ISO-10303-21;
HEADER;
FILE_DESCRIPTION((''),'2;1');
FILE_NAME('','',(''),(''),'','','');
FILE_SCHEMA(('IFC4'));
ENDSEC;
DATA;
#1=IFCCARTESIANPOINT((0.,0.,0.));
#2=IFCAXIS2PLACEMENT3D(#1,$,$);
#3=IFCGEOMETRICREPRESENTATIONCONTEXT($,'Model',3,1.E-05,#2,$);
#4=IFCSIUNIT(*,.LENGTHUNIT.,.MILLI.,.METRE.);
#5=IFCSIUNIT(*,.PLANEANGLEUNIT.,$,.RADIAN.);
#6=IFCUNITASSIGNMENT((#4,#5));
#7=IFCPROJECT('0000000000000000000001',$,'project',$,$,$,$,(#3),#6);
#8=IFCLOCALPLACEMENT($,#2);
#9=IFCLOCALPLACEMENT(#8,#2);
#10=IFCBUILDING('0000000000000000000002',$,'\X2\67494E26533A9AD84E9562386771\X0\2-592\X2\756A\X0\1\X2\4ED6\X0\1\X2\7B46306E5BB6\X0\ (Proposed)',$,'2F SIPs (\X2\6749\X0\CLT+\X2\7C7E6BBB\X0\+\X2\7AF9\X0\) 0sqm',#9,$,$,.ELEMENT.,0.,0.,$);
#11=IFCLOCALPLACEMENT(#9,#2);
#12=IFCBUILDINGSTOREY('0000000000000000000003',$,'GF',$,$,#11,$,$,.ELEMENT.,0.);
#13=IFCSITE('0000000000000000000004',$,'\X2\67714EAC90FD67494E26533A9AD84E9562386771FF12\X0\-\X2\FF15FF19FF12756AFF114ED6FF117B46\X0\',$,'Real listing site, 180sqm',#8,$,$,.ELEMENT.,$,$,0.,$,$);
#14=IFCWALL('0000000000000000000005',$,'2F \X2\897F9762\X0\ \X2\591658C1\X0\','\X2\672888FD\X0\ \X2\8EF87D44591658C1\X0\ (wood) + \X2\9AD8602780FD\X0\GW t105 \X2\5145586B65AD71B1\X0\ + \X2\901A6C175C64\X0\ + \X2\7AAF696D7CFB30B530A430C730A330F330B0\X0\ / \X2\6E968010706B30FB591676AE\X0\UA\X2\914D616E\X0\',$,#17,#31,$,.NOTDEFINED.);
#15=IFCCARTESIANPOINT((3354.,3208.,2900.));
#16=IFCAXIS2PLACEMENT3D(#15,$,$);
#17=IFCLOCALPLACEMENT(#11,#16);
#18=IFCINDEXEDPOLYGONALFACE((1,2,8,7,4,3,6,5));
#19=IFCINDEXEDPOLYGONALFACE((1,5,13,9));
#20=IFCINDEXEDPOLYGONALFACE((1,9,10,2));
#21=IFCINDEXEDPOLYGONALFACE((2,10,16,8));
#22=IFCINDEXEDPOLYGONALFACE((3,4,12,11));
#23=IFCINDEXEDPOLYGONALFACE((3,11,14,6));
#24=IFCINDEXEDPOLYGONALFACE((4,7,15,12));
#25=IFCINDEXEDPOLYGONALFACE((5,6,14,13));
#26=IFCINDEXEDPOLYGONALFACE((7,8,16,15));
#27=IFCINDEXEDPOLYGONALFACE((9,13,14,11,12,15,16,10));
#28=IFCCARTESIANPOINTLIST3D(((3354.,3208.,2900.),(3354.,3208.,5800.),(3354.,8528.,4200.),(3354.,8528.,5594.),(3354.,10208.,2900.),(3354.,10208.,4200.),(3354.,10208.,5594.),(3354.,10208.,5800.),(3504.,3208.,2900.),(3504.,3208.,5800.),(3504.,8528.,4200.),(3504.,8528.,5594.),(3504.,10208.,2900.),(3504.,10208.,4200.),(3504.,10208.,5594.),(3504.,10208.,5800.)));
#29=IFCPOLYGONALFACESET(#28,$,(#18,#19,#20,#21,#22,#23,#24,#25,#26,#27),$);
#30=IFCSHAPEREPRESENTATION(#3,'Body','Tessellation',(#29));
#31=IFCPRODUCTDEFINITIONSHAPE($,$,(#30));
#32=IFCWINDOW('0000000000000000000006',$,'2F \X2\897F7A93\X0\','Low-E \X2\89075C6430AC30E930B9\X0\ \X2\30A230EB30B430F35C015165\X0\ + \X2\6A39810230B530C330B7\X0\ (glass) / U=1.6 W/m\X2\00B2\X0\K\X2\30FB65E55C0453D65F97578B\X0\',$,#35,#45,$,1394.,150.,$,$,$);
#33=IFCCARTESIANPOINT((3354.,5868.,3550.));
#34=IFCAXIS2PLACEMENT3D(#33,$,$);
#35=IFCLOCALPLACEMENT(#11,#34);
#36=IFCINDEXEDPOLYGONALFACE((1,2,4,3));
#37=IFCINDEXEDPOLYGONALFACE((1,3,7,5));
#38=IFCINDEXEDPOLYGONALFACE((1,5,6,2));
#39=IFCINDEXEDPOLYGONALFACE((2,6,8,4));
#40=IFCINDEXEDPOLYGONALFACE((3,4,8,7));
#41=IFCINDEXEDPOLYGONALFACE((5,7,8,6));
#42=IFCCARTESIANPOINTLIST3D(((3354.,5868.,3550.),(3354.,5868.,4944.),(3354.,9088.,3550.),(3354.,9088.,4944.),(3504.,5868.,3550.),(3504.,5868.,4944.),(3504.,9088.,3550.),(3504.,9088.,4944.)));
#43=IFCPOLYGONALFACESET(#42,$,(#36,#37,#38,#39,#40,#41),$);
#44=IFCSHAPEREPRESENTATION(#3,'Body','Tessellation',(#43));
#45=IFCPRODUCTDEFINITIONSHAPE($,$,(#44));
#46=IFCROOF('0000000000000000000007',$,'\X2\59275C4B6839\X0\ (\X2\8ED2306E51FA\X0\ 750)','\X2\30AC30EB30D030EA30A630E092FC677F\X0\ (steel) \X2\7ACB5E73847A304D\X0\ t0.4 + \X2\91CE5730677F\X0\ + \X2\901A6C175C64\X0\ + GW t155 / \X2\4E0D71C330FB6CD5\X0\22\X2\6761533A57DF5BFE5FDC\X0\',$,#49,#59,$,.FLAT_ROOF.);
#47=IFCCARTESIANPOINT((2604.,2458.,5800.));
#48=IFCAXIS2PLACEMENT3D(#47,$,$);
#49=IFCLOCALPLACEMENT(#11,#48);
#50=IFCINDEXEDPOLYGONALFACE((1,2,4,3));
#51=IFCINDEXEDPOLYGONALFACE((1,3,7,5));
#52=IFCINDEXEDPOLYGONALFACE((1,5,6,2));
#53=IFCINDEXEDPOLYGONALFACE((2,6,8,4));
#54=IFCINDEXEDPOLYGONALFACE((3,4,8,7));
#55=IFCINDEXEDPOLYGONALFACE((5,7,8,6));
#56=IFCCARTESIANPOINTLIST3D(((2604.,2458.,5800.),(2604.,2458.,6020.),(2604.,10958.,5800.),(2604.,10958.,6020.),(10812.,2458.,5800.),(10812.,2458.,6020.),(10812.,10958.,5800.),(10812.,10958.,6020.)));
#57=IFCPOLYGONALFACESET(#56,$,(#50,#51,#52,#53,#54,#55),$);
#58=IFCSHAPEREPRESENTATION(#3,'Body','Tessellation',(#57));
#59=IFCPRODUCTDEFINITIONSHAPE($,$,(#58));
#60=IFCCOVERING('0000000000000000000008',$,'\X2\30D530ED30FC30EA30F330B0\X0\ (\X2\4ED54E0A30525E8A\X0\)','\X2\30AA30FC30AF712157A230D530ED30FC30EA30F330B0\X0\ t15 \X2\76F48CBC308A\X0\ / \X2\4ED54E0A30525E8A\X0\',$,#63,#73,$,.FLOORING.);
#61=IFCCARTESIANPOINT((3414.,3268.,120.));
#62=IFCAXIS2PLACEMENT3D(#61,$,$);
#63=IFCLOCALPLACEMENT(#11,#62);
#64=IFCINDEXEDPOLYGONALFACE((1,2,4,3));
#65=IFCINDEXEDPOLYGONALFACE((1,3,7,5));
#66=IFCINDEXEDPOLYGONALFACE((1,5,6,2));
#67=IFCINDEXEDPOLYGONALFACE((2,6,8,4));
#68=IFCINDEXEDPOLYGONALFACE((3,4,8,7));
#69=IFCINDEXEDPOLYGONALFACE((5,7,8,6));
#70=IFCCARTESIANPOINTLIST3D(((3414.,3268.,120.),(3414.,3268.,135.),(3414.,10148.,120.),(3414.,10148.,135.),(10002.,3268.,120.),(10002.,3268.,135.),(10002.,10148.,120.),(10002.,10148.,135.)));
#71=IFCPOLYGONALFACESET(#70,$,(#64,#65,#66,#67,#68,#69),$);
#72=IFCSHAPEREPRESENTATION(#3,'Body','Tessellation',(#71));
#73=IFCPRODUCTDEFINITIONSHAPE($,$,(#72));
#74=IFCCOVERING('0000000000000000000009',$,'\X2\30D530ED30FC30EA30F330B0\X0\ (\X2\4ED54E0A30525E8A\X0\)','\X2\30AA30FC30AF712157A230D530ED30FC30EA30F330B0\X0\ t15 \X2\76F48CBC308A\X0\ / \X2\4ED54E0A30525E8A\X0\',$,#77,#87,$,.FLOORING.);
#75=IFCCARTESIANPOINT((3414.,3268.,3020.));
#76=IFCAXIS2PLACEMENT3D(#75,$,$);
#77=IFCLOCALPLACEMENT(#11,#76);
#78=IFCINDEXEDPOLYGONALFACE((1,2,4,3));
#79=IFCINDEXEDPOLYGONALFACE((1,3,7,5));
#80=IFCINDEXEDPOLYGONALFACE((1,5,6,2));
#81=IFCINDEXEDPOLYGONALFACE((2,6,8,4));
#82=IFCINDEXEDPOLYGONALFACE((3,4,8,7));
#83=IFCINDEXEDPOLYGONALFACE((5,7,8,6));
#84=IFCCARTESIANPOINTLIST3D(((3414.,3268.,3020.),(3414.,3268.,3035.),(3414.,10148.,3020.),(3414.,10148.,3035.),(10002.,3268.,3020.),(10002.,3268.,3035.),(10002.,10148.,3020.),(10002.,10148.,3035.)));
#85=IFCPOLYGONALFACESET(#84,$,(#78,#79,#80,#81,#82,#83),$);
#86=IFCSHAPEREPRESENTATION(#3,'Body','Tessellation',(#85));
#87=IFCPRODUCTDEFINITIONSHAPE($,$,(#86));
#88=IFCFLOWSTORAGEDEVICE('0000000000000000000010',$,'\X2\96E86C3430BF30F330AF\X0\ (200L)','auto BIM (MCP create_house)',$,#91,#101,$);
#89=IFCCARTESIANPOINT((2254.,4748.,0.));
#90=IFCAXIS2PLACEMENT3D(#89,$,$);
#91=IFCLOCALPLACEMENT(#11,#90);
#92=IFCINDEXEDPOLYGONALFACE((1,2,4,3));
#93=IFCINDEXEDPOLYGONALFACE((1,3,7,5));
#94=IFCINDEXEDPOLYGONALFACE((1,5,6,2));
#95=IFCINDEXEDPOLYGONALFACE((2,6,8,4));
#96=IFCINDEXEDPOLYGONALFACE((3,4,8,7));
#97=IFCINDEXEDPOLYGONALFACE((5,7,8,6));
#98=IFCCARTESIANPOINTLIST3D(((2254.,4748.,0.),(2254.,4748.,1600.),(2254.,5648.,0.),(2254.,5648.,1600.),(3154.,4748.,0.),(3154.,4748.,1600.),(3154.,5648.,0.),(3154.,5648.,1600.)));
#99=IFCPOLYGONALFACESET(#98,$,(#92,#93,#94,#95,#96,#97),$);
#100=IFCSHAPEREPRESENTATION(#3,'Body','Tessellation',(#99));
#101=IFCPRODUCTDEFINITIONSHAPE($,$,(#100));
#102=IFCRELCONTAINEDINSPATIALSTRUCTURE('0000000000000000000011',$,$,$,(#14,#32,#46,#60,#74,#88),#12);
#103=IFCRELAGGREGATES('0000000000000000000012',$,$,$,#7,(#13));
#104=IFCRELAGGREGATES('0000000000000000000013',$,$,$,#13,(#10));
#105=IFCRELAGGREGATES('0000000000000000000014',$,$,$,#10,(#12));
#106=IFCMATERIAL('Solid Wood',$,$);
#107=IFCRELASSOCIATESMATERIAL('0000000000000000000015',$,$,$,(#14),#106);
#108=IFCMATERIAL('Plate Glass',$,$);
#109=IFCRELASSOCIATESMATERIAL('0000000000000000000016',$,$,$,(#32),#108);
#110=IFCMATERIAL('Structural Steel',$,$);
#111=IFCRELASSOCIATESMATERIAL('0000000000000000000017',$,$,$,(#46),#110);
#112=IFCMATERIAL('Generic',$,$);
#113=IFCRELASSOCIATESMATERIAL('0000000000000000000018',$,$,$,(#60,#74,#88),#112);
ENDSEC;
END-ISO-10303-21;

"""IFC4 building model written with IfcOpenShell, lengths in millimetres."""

from ifc_helpers import new_model, si_unit, frame, frame_2d, origin, place, context, project, spatial, rectangle, extrude, material, element, fill, save


model = new_model("IFC4")

# Units and contexts
model_context = context("Model", 3, precision=1e-05, world=origin())
ifc_project = project(units=[si_unit("LENGTHUNIT", "METRE", prefix="MILLI"), si_unit("PLANEANGLEUNIT", "RADIAN")], contexts=[model_context])

# Site, building, storey
site_placement = place(None, origin())
site = spatial("IfcSite", under=ifc_project, at=site_placement, Name="東京都杉並区高井戸東２-５９２番１他１筆", ObjectType="Real listing site, 180sqm", CompositionType="ELEMENT", RefElevation=0.0)
building_placement = place(site_placement, origin())
building = spatial("IfcBuilding", under=site, at=building_placement, Name="杉並区高井戸東2-592番1他1筆の家 (Proposed)", ObjectType="2F SIPs (杉CLT+籾殻+竹) 0sqm", CompositionType="ELEMENT", ElevationOfRefHeight=0.0, ElevationOfTerrain=0.0)
storey_placement = place(building_placement, origin())
storey = spatial("IfcBuildingStorey", under=building, at=storey_placement, Name="GF", CompositionType="ELEMENT", Elevation=0.0)

# Shared definitions
ifc_material_1 = material(Name="Solid Wood")

# Shared definitions
ifc_material_2 = material(Name="Plate Glass")

# Wall, opening, window
wall_1_placement = place(storey_placement, frame((3354.0, 3208.0, 2900.0)))
wall_1 = element("IfcWall", 1, at=wall_1_placement, inside=storey, material=ifc_material_1, Name="2F 西面 外壁", Description="木製 軸組外壁 (wood) + 高性能GW t105 充填断熱 + 通気層 + 窯業系サイディング / 準耐火・外皮UA配慮", PredefinedType="NOTDEFINED", context=model_context, shape_type="SweptSolid", body=[
    extrude(rectangle(XDim=150.0, YDim=7000.0, at=frame_2d((75.0, 3500.0))), frame((3354.0, 3208.0, 2900.0)), (0.0, 0.0, 1.0), 2900.0),
])
opening_1_placement = place(storey_placement, frame((3354.0, 5868.0, 3550.0)))
opening_1 = element("IfcOpeningElement", 2, at=opening_1_placement, cuts=wall_1, PredefinedType="NOTDEFINED", context=model_context, shape_type="SweptSolid", body=[
    extrude(rectangle(XDim=150.0, YDim=3220.0, at=frame_2d((75.0, 1610.0))), frame((3354.0, 5868.0, 3550.0)), (0.0, 0.0, 1.0), 1394.0),
])
window_1_placement = place(storey_placement, frame((3354.0, 5868.0, 3550.0)))
window_1 = element("IfcWindow", 3, at=window_1_placement, inside=storey, material=ifc_material_2, Name="2F 西窓", Description="Low-E 複層ガラス アルゴン封入 + 樹脂サッシ (glass) / U=1.6 W/m²K・日射取得型", OverallHeight=1394.0, OverallWidth=150.0, context=model_context, shape_type="SweptSolid", body=[
    extrude(rectangle(XDim=150.0, YDim=3220.0, at=frame_2d((75.0, 1610.0))), frame((3354.0, 5868.0, 3550.0)), (0.0, 0.0, 1.0), 1394.0),
])
fill(opening_1, window_1)

# Roof
ifc_material_3 = material(Name="Structural Steel")
roof_placement = place(storey_placement, frame((2604.0, 2458.0, 5800.0)))
element("IfcRoof", 4, at=roof_placement, inside=storey, material=ifc_material_3, Name="大屋根 (軒の出 750)", Description="ガルバリウム鋼板 (steel) 立平葺き t0.4 + 野地板 + 通気層 + GW t155 / 不燃・法22条区域対応", PredefinedType="FLAT_ROOF", context=model_context, shape_type="SweptSolid", body=[
    extrude(rectangle(XDim=8208.0, YDim=8500.0, at=frame_2d((4104.0, 4250.0))), frame((2604.0, 2458.0, 5800.0)), (0.0, 0.0, 1.0), 220.0),
])

# Coverings
ifc_material_4 = material(Name="Generic")
covering_1_placement = place(storey_placement, frame((3414.0, 3268.0, 120.0)))
element("IfcCovering", 5, at=covering_1_placement, inside=storey, material=ifc_material_4, Name="フローリング (仕上げ床)", Description="オーク無垢フローリング t15 直貼り / 仕上げ床", PredefinedType="FLOORING", context=model_context, shape_type="SweptSolid", body=[
    extrude(rectangle(XDim=6588.0, YDim=6880.0, at=frame_2d((3294.0, 3440.0))), frame((3414.0, 3268.0, 120.0)), (0.0, 0.0, 1.0), 15.0),
])
covering_2_placement = place(storey_placement, frame((3414.0, 3268.0, 3020.0)))
element("IfcCovering", 6, at=covering_2_placement, inside=storey, material=ifc_material_4, Name="フローリング (仕上げ床)", Description="オーク無垢フローリング t15 直貼り / 仕上げ床", PredefinedType="FLOORING", context=model_context, shape_type="SweptSolid", body=[
    extrude(rectangle(XDim=6588.0, YDim=6880.0, at=frame_2d((3294.0, 3440.0))), frame((3414.0, 3268.0, 3020.0)), (0.0, 0.0, 1.0), 15.0),
])

# Flow storage device
flow_storage_device_placement = place(storey_placement, frame((2254.0, 4748.0, 0.0)))
element("IfcFlowStorageDevice", 7, at=flow_storage_device_placement, inside=storey, material=ifc_material_4, Name="雨水タンク (200L)", Description="auto BIM (MCP create_house)", context=model_context, shape_type="SweptSolid", body=[
    extrude(rectangle(XDim=900.0, YDim=900.0, at=frame_2d((450.0, 450.0))), frame((2254.0, 4748.0, 0.0)), (0.0, 0.0, 1.0), 1600.0),
])

save(model, "model.ifc")
